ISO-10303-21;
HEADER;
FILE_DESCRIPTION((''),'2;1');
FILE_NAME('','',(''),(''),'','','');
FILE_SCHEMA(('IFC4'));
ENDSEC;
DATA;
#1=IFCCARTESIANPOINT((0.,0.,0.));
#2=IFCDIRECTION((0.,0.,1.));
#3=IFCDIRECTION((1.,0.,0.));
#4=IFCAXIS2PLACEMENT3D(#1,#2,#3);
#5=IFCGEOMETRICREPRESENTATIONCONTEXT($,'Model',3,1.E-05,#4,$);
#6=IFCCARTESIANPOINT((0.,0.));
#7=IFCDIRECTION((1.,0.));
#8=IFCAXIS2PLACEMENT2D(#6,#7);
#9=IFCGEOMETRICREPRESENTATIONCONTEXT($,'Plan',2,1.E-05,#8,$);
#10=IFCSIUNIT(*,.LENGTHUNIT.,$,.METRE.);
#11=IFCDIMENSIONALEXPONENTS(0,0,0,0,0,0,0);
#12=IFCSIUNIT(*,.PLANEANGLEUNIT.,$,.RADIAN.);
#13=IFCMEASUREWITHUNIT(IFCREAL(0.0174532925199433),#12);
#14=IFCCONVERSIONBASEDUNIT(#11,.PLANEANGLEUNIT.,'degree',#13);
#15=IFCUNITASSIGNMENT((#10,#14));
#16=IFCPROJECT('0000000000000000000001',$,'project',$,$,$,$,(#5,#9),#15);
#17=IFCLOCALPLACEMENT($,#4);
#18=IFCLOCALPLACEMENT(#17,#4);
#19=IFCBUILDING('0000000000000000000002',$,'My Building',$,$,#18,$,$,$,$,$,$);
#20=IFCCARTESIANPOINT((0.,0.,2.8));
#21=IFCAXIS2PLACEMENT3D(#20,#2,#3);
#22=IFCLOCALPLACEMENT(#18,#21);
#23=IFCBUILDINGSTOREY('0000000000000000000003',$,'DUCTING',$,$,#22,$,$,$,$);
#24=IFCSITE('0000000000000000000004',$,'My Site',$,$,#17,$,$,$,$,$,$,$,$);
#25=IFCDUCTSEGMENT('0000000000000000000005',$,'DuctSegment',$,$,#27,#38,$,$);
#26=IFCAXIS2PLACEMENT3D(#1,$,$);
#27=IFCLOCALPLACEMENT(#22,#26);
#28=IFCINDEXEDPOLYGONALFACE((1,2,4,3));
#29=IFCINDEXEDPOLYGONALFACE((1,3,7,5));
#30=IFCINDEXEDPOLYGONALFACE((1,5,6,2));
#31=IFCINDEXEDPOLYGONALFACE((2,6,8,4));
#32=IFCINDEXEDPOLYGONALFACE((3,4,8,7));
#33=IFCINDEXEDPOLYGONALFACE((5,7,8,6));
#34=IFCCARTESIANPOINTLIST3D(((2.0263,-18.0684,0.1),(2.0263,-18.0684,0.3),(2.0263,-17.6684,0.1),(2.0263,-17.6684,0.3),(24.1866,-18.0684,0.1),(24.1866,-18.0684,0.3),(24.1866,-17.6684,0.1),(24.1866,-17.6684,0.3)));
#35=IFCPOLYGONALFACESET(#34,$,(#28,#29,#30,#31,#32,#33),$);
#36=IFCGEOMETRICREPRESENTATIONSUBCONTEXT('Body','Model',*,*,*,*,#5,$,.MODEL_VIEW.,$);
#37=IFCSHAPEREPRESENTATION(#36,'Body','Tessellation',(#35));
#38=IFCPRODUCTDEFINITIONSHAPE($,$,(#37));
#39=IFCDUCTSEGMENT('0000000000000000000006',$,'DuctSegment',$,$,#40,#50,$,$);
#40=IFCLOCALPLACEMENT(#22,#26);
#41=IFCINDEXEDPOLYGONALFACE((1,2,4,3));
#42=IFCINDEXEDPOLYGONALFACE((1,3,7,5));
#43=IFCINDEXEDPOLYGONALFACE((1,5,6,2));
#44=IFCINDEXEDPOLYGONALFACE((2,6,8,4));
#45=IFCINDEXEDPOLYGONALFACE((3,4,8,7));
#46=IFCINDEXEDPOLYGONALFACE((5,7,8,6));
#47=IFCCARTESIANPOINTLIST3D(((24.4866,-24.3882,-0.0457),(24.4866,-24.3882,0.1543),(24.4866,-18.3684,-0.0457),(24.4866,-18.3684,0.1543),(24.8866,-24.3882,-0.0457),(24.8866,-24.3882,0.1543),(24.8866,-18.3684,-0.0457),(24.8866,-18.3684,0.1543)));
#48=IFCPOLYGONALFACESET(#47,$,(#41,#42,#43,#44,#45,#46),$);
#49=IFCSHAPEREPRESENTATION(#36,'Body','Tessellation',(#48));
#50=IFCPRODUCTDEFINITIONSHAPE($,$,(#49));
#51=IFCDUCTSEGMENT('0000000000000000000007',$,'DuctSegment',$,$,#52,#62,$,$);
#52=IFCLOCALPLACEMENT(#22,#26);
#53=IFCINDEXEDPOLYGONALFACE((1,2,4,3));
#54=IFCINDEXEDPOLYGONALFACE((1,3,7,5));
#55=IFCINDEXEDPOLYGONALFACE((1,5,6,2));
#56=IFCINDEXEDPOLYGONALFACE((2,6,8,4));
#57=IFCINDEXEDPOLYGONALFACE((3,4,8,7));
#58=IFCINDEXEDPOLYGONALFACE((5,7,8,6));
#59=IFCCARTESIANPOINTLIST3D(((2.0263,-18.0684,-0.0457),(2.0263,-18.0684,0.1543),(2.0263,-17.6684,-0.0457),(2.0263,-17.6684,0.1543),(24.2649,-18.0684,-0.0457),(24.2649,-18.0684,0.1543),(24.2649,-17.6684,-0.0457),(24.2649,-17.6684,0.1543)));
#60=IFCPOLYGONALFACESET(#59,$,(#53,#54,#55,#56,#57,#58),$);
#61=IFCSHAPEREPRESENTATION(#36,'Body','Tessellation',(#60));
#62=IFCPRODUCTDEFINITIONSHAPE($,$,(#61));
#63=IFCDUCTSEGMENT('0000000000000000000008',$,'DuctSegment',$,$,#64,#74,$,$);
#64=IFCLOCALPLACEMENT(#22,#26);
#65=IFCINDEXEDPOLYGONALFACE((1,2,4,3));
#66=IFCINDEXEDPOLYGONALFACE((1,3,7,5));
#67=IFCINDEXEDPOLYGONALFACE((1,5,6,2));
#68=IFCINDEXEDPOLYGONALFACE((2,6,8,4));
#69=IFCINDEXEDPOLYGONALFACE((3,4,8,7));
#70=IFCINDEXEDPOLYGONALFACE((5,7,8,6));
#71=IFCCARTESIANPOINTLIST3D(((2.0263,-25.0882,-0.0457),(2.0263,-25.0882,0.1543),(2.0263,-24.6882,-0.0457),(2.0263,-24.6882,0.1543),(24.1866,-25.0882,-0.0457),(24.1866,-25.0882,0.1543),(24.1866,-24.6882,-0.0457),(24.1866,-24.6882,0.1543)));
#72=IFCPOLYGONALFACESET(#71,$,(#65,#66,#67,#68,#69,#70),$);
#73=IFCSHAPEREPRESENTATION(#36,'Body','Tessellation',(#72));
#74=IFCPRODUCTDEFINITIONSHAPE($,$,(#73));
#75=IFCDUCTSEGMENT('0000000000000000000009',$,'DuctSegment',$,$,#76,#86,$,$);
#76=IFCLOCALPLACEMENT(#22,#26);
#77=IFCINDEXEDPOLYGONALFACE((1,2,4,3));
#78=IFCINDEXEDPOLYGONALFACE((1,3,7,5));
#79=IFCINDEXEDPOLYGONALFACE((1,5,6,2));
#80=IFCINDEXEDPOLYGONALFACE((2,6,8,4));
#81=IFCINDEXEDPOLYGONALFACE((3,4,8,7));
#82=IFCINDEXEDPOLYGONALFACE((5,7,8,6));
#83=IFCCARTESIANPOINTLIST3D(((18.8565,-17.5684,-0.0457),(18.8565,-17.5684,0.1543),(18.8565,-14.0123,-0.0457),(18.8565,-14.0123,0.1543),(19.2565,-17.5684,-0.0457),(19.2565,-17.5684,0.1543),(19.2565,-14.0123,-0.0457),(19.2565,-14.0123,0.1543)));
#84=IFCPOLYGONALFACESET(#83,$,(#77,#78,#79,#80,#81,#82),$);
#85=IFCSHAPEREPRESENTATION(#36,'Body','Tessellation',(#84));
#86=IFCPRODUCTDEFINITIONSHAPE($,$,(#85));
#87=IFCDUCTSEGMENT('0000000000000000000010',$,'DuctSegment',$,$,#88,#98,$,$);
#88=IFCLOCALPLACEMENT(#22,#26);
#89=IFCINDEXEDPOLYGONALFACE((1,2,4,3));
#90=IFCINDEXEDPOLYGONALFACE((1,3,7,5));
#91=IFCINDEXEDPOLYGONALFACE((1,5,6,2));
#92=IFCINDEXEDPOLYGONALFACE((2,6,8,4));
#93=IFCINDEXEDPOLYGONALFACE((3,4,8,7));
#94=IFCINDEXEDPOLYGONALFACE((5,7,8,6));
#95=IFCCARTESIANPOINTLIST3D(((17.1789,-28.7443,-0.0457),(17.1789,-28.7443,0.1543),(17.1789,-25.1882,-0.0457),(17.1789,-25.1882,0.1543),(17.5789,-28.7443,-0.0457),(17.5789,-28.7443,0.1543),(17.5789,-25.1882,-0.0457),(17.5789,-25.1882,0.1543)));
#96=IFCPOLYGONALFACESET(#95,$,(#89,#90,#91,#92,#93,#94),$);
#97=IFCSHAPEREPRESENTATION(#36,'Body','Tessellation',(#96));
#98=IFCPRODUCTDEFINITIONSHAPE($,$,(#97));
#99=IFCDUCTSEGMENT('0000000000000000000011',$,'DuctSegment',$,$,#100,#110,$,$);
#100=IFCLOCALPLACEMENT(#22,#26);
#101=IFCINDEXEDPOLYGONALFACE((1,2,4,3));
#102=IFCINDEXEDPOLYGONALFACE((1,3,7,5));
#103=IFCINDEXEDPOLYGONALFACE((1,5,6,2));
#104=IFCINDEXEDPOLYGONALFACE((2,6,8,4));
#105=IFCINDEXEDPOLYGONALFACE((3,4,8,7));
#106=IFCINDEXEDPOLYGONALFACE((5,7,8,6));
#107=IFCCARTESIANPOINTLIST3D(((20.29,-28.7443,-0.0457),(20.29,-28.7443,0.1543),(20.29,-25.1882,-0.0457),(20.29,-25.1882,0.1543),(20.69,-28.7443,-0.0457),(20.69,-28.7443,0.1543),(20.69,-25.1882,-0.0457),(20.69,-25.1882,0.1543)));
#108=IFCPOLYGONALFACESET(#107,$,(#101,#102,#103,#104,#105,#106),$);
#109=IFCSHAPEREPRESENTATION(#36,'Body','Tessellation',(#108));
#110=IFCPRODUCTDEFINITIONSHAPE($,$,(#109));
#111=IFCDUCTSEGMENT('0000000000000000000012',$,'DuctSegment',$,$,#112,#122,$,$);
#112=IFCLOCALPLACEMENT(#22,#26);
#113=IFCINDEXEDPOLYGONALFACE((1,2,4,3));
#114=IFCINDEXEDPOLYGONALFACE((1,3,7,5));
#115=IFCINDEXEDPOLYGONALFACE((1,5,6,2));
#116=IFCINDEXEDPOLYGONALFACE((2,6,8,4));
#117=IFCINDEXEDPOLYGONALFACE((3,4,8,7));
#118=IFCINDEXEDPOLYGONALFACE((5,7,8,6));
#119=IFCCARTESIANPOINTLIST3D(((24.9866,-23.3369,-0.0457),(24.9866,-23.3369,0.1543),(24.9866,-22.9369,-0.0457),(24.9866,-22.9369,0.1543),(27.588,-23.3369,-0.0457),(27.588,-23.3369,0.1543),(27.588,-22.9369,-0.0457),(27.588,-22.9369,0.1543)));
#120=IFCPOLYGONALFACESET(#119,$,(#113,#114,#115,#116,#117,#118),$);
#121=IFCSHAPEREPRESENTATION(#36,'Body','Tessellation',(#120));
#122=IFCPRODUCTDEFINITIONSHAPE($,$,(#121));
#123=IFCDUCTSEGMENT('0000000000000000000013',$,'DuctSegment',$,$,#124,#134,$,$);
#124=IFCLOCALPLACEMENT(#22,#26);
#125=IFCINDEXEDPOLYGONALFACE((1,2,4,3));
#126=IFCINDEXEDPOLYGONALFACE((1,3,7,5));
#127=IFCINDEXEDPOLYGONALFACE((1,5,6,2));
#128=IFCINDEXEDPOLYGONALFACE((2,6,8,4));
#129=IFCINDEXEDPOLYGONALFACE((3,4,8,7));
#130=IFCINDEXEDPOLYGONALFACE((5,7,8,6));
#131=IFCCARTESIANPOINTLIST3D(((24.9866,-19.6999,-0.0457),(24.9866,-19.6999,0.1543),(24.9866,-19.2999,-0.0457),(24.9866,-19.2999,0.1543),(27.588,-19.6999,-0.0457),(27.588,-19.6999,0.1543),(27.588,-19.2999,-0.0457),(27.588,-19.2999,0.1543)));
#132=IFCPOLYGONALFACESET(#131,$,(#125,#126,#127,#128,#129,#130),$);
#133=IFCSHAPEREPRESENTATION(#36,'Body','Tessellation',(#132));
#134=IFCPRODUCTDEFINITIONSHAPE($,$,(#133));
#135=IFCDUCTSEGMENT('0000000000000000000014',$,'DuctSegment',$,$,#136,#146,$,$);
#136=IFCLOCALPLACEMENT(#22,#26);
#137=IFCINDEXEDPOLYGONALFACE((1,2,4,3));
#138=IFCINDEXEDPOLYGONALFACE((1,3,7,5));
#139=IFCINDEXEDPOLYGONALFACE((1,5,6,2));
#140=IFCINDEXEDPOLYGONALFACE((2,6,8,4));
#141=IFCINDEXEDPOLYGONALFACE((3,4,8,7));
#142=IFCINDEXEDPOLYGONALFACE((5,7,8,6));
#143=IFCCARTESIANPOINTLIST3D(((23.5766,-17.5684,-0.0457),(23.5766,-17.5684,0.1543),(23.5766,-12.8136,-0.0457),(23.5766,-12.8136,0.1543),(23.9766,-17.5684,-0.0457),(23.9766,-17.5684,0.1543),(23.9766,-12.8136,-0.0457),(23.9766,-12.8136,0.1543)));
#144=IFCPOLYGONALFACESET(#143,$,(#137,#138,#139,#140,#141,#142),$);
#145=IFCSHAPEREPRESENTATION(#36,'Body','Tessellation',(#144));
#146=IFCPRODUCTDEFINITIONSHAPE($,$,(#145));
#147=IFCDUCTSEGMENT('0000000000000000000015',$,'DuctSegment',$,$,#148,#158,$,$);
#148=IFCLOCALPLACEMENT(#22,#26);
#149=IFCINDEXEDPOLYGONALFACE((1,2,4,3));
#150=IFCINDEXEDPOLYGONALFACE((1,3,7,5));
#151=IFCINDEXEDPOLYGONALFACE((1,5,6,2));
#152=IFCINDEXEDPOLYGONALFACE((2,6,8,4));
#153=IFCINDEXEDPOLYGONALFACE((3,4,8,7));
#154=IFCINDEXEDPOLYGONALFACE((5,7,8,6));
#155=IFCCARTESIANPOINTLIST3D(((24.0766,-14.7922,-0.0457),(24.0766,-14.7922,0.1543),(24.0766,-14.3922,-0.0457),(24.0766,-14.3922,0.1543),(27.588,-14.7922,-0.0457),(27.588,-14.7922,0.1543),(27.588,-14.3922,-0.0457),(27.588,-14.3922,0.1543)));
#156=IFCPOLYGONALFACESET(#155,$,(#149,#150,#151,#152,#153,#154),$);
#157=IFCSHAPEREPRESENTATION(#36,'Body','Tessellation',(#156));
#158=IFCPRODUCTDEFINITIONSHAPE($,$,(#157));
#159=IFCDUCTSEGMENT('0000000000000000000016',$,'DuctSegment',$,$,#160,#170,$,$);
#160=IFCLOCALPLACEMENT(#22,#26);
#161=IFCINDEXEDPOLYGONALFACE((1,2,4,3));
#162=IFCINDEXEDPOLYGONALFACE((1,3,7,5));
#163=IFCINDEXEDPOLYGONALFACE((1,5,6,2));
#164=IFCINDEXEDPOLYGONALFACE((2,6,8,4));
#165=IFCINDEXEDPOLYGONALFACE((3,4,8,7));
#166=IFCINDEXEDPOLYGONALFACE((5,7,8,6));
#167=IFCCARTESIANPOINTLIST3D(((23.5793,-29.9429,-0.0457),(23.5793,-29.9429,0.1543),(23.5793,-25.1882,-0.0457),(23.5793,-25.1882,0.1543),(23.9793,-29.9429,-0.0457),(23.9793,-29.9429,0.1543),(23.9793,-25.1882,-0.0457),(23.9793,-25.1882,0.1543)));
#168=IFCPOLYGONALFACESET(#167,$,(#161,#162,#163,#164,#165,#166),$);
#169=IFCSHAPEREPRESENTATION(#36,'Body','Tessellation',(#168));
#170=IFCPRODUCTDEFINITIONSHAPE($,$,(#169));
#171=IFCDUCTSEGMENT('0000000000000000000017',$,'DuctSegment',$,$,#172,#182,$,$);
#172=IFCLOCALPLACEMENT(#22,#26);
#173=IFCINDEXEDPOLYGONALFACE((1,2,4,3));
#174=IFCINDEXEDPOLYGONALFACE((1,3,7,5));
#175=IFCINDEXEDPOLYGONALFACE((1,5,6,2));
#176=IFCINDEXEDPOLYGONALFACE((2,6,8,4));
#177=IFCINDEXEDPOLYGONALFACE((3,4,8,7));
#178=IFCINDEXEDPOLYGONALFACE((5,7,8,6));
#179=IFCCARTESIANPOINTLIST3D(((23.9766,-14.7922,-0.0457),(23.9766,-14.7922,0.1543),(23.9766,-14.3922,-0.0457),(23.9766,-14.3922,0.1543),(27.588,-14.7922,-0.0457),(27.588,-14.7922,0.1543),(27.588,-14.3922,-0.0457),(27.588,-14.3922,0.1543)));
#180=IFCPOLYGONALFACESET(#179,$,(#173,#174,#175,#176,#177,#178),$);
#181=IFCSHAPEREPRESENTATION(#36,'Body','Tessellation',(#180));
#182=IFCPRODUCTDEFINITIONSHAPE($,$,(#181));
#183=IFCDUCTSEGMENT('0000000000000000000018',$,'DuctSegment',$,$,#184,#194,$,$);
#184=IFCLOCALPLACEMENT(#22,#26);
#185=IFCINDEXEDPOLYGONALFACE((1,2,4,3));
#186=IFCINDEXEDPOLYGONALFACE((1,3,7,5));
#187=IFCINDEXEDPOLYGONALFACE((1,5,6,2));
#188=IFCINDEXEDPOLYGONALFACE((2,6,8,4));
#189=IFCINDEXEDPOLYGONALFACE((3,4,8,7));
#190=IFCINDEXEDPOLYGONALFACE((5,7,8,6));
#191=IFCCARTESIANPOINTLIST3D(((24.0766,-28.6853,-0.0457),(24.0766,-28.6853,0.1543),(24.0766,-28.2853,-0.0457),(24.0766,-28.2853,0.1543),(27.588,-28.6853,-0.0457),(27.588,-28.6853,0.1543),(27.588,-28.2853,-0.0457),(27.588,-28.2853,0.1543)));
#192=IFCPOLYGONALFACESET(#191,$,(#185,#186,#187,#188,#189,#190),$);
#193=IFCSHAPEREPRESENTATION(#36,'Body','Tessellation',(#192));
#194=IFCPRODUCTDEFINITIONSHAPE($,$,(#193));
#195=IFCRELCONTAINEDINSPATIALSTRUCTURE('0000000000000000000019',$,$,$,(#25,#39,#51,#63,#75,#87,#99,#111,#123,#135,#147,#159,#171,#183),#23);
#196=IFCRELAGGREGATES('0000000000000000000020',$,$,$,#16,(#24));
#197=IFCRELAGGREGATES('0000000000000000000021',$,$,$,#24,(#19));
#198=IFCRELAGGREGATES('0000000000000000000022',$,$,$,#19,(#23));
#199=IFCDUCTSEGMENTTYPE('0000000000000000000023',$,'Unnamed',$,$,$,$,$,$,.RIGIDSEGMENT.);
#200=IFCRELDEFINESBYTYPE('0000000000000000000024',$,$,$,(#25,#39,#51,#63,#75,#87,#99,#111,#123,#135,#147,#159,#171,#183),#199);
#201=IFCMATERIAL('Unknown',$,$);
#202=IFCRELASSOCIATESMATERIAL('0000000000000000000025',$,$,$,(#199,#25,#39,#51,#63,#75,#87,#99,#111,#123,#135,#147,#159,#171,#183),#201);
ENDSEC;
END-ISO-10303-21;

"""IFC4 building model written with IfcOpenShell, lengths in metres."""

from ifc_helpers import new_model, entity, si_unit, converted_unit, frame, origin_with_axes, origin_2d_with_axis, place, context, subcontext, project, spatial, rectangle, extrude, material, material_profile, profile_set, profile_usage, type_object, element, save


model = new_model("IFC4")

# Units and contexts
model_context = context("Model", 3, precision=1e-05, world=origin_with_axes())
plan_context = context("Plan", 2, precision=1e-05, world=origin_2d_with_axis())
body_context = subcontext(model_context, "Body", "Model", "MODEL_VIEW")
ifc_project = project(units=[si_unit("LENGTHUNIT", "METRE"), converted_unit("PLANEANGLEUNIT", "degree", entity("IfcReal", 0.0174532925199433), si_unit("PLANEANGLEUNIT", "RADIAN"), dimensions=[0, 0, 0, 0, 0, 0, 0])], contexts=[model_context, plan_context])

# Site, building, storey
site_placement = place(None, origin_with_axes())
site = spatial("IfcSite", under=ifc_project, at=site_placement, Name="My Site")
building_placement = place(site_placement, origin_with_axes())
building = spatial("IfcBuilding", under=site, at=building_placement, Name="My Building")
storey_placement = place(building_placement, frame((0.0, 0.0, 2.8), z_axis=(0.0, 0.0, 1.0), x_axis=(1.0, 0.0, 0.0)))
storey = spatial("IfcBuildingStorey", under=building, at=storey_placement, Name="DUCTING")

# Duct segments
ifc_material = material(Name="Unknown")
ifc_material_profile_1 = material_profile(ifc_material, rectangle(XDim=0.4, YDim=0.2))
ifc_profile_set_1 = profile_set([ifc_material_profile_1])
ifc_profile_usage_1 = profile_usage(ifc_profile_set_1, cardinal=5)
duct_segment_type = type_object("IfcDuctSegmentType", Name="Unnamed", PredefinedType="RIGIDSEGMENT", material=ifc_profile_set_1)
duct_segment_1_placement = place(storey_placement, frame((24.1866, -17.8684, 0.2), z_axis=(-1.0, 0.0, 0.0), x_axis=(0.0, -1.0, 0.0)))
element("IfcDuctSegment", 1, at=duct_segment_1_placement, inside=storey, type_object=duct_segment_type, material=ifc_profile_usage_1, Name="DuctSegment", context=body_context, shape_type="SweptSolid", body=[
    extrude(rectangle(XDim=0.4, YDim=0.2), origin_with_axes(), (0.0, 0.0, 1.0), 22.1603),
])
ifc_profile_usage_2 = profile_usage(ifc_profile_set_1, cardinal=5)
duct_segment_2_placement = place(storey_placement, frame((24.6866, -18.3684, 0.0543), z_axis=(0.0, -1.0, 0.0), x_axis=(1.0, 0.0, 0.0)))
element("IfcDuctSegment", 2, at=duct_segment_2_placement, inside=storey, type_object=duct_segment_type, material=ifc_profile_usage_2, Name="DuctSegment", context=body_context, shape_type="SweptSolid", body=[
    extrude(rectangle(XDim=0.4, YDim=0.2), origin_with_axes(), (0.0, 0.0, 1.0), 6.0198),
])
ifc_profile_usage_3 = profile_usage(ifc_profile_set_1, cardinal=5)
duct_segment_3_placement = place(storey_placement, frame((24.2649, -17.8684, 0.0543), z_axis=(-1.0, 0.0, 0.0), x_axis=(0.0, -1.0, 0.0)))
element("IfcDuctSegment", 3, at=duct_segment_3_placement, inside=storey, type_object=duct_segment_type, material=ifc_profile_usage_3, Name="DuctSegment", context=body_context, shape_type="SweptSolid", body=[
    extrude(rectangle(XDim=0.4, YDim=0.2), origin_with_axes(), (0.0, 0.0, 1.0), 22.2386),
])
ifc_profile_usage_4 = profile_usage(ifc_profile_set_1, cardinal=5)
duct_segment_4_placement = place(storey_placement, frame((24.1866, -24.8882, 0.0543), z_axis=(-1.0, 0.0, 0.0), x_axis=(0.0, -1.0, 0.0)))
element("IfcDuctSegment", 4, at=duct_segment_4_placement, inside=storey, type_object=duct_segment_type, material=ifc_profile_usage_4, Name="DuctSegment", context=body_context, shape_type="SweptSolid", body=[
    extrude(rectangle(XDim=0.4, YDim=0.2), origin_with_axes(), (0.0, 0.0, 1.0), 22.1603),
])
ifc_profile_usage_5 = profile_usage(ifc_profile_set_1, cardinal=5)
duct_segment_5_placement = place(storey_placement, frame((19.0565, -14.0123, 0.0543), z_axis=(0.0, -1.0, 0.0), x_axis=(1.0, 0.0, 0.0)))
element("IfcDuctSegment", 5, at=duct_segment_5_placement, inside=storey, type_object=duct_segment_type, material=ifc_profile_usage_5, Name="DuctSegment", context=body_context, shape_type="SweptSolid", body=[
    extrude(rectangle(XDim=0.4, YDim=0.2), origin_with_axes(), (0.0, 0.0, 1.0), 3.5561),
])
ifc_profile_usage_6 = profile_usage(ifc_profile_set_1, cardinal=5)
duct_segment_6_placement = place(storey_placement, frame((17.3789, -28.7443, 0.0543), z_axis=(0.0, 1.0, 0.0), x_axis=(-1.0, 0.0, 0.0)))
element("IfcDuctSegment", 6, at=duct_segment_6_placement, inside=storey, type_object=duct_segment_type, material=ifc_profile_usage_6, Name="DuctSegment", context=body_context, shape_type="SweptSolid", body=[
    extrude(rectangle(XDim=0.4, YDim=0.2), origin_with_axes(), (0.0, 0.0, 1.0), 3.5561),
])
ifc_profile_usage_7 = profile_usage(ifc_profile_set_1, cardinal=5)
duct_segment_7_placement = place(storey_placement, frame((20.49, -28.7443, 0.0543), z_axis=(0.0, 1.0, 0.0), x_axis=(-1.0, 0.0, 0.0)))
element("IfcDuctSegment", 7, at=duct_segment_7_placement, inside=storey, type_object=duct_segment_type, material=ifc_profile_usage_7, Name="DuctSegment", context=body_context, shape_type="SweptSolid", body=[
    extrude(rectangle(XDim=0.4, YDim=0.2), origin_with_axes(), (0.0, 0.0, 1.0), 3.5561),
])
ifc_profile_usage_8 = profile_usage(ifc_profile_set_1, cardinal=5)
duct_segment_8_placement = place(storey_placement, frame((27.588, -23.1369, 0.0543), z_axis=(-1.0, 0.0, 0.0), x_axis=(0.0, -1.0, 0.0)))
element("IfcDuctSegment", 8, at=duct_segment_8_placement, inside=storey, type_object=duct_segment_type, material=ifc_profile_usage_8, Name="DuctSegment", context=body_context, shape_type="SweptSolid", body=[
    extrude(rectangle(XDim=0.4, YDim=0.2), origin_with_axes(), (0.0, 0.0, 1.0), 2.6013),
])
ifc_profile_usage_9 = profile_usage(ifc_profile_set_1, cardinal=5)
duct_segment_9_placement = place(storey_placement, frame((27.588, -19.4999, 0.0543), z_axis=(-1.0, 0.0, 0.0), x_axis=(0.0, -1.0, 0.0)))
element("IfcDuctSegment", 9, at=duct_segment_9_placement, inside=storey, type_object=duct_segment_type, material=ifc_profile_usage_9, Name="DuctSegment", context=body_context, shape_type="SweptSolid", body=[
    extrude(rectangle(XDim=0.4, YDim=0.2), origin_with_axes(), (0.0, 0.0, 1.0), 2.6013),
])
ifc_profile_usage_10 = profile_usage(ifc_profile_set_1, cardinal=5)
duct_segment_10_placement = place(storey_placement, frame((23.7766, -12.8136, 0.0543), z_axis=(0.0, -1.0, 0.0), x_axis=(1.0, 0.0, 0.0)))
element("IfcDuctSegment", 10, at=duct_segment_10_placement, inside=storey, type_object=duct_segment_type, material=ifc_profile_usage_10, Name="DuctSegment", context=body_context, shape_type="SweptSolid", body=[
    extrude(rectangle(XDim=0.4, YDim=0.2), origin_with_axes(), (0.0, 0.0, 1.0), 4.7548),
])
ifc_profile_usage_11 = profile_usage(ifc_profile_set_1, cardinal=5)
duct_segment_11_placement = place(storey_placement, frame((27.588, -14.5922, 0.0543), z_axis=(-1.0, 0.0, 0.0), x_axis=(0.0, -1.0, 0.0)))
element("IfcDuctSegment", 11, at=duct_segment_11_placement, inside=storey, type_object=duct_segment_type, material=ifc_profile_usage_11, Name="DuctSegment", context=body_context, shape_type="SweptSolid", body=[
    extrude(rectangle(XDim=0.4, YDim=0.2), origin_with_axes(), (0.0, 0.0, 1.0), 3.5114),
])
ifc_profile_usage_12 = profile_usage(ifc_profile_set_1, cardinal=5)
duct_segment_12_placement = place(storey_placement, frame((23.7793, -29.9429, 0.0543), z_axis=(0.0, 1.0, 0.0), x_axis=(-1.0, 0.0, 0.0)))
element("IfcDuctSegment", 12, at=duct_segment_12_placement, inside=storey, type_object=duct_segment_type, material=ifc_profile_usage_12, Name="DuctSegment", context=body_context, shape_type="SweptSolid", body=[
    extrude(rectangle(XDim=0.4, YDim=0.2), origin_with_axes(), (0.0, 0.0, 1.0), 4.7548),
])
ifc_profile_usage_13 = profile_usage(ifc_profile_set_1, cardinal=5)
duct_segment_13_placement = place(storey_placement, frame((27.588, -14.5922, 0.0543), z_axis=(-1.0, 0.0, 0.0), x_axis=(0.0, -1.0, 0.0)))
element("IfcDuctSegment", 13, at=duct_segment_13_placement, inside=storey, type_object=duct_segment_type, material=ifc_profile_usage_13, Name="DuctSegment", context=body_context, shape_type="SweptSolid", body=[
    extrude(rectangle(XDim=0.4, YDim=0.2), origin_with_axes(), (0.0, 0.0, 1.0), 3.6114),
])
ifc_profile_usage_14 = profile_usage(ifc_profile_set_1, cardinal=5)
duct_segment_14_placement = place(storey_placement, frame((27.588, -28.4853, 0.0543), z_axis=(-1.0, 0.0, 0.0), x_axis=(0.0, -1.0, 0.0)))
element("IfcDuctSegment", 14, at=duct_segment_14_placement, inside=storey, type_object=duct_segment_type, material=ifc_profile_usage_14, Name="DuctSegment", context=body_context, shape_type="SweptSolid", body=[
    extrude(rectangle(XDim=0.4, YDim=0.2), origin_with_axes(), (0.0, 0.0, 1.0), 3.5114),
])

save(model, "model.ifc")
